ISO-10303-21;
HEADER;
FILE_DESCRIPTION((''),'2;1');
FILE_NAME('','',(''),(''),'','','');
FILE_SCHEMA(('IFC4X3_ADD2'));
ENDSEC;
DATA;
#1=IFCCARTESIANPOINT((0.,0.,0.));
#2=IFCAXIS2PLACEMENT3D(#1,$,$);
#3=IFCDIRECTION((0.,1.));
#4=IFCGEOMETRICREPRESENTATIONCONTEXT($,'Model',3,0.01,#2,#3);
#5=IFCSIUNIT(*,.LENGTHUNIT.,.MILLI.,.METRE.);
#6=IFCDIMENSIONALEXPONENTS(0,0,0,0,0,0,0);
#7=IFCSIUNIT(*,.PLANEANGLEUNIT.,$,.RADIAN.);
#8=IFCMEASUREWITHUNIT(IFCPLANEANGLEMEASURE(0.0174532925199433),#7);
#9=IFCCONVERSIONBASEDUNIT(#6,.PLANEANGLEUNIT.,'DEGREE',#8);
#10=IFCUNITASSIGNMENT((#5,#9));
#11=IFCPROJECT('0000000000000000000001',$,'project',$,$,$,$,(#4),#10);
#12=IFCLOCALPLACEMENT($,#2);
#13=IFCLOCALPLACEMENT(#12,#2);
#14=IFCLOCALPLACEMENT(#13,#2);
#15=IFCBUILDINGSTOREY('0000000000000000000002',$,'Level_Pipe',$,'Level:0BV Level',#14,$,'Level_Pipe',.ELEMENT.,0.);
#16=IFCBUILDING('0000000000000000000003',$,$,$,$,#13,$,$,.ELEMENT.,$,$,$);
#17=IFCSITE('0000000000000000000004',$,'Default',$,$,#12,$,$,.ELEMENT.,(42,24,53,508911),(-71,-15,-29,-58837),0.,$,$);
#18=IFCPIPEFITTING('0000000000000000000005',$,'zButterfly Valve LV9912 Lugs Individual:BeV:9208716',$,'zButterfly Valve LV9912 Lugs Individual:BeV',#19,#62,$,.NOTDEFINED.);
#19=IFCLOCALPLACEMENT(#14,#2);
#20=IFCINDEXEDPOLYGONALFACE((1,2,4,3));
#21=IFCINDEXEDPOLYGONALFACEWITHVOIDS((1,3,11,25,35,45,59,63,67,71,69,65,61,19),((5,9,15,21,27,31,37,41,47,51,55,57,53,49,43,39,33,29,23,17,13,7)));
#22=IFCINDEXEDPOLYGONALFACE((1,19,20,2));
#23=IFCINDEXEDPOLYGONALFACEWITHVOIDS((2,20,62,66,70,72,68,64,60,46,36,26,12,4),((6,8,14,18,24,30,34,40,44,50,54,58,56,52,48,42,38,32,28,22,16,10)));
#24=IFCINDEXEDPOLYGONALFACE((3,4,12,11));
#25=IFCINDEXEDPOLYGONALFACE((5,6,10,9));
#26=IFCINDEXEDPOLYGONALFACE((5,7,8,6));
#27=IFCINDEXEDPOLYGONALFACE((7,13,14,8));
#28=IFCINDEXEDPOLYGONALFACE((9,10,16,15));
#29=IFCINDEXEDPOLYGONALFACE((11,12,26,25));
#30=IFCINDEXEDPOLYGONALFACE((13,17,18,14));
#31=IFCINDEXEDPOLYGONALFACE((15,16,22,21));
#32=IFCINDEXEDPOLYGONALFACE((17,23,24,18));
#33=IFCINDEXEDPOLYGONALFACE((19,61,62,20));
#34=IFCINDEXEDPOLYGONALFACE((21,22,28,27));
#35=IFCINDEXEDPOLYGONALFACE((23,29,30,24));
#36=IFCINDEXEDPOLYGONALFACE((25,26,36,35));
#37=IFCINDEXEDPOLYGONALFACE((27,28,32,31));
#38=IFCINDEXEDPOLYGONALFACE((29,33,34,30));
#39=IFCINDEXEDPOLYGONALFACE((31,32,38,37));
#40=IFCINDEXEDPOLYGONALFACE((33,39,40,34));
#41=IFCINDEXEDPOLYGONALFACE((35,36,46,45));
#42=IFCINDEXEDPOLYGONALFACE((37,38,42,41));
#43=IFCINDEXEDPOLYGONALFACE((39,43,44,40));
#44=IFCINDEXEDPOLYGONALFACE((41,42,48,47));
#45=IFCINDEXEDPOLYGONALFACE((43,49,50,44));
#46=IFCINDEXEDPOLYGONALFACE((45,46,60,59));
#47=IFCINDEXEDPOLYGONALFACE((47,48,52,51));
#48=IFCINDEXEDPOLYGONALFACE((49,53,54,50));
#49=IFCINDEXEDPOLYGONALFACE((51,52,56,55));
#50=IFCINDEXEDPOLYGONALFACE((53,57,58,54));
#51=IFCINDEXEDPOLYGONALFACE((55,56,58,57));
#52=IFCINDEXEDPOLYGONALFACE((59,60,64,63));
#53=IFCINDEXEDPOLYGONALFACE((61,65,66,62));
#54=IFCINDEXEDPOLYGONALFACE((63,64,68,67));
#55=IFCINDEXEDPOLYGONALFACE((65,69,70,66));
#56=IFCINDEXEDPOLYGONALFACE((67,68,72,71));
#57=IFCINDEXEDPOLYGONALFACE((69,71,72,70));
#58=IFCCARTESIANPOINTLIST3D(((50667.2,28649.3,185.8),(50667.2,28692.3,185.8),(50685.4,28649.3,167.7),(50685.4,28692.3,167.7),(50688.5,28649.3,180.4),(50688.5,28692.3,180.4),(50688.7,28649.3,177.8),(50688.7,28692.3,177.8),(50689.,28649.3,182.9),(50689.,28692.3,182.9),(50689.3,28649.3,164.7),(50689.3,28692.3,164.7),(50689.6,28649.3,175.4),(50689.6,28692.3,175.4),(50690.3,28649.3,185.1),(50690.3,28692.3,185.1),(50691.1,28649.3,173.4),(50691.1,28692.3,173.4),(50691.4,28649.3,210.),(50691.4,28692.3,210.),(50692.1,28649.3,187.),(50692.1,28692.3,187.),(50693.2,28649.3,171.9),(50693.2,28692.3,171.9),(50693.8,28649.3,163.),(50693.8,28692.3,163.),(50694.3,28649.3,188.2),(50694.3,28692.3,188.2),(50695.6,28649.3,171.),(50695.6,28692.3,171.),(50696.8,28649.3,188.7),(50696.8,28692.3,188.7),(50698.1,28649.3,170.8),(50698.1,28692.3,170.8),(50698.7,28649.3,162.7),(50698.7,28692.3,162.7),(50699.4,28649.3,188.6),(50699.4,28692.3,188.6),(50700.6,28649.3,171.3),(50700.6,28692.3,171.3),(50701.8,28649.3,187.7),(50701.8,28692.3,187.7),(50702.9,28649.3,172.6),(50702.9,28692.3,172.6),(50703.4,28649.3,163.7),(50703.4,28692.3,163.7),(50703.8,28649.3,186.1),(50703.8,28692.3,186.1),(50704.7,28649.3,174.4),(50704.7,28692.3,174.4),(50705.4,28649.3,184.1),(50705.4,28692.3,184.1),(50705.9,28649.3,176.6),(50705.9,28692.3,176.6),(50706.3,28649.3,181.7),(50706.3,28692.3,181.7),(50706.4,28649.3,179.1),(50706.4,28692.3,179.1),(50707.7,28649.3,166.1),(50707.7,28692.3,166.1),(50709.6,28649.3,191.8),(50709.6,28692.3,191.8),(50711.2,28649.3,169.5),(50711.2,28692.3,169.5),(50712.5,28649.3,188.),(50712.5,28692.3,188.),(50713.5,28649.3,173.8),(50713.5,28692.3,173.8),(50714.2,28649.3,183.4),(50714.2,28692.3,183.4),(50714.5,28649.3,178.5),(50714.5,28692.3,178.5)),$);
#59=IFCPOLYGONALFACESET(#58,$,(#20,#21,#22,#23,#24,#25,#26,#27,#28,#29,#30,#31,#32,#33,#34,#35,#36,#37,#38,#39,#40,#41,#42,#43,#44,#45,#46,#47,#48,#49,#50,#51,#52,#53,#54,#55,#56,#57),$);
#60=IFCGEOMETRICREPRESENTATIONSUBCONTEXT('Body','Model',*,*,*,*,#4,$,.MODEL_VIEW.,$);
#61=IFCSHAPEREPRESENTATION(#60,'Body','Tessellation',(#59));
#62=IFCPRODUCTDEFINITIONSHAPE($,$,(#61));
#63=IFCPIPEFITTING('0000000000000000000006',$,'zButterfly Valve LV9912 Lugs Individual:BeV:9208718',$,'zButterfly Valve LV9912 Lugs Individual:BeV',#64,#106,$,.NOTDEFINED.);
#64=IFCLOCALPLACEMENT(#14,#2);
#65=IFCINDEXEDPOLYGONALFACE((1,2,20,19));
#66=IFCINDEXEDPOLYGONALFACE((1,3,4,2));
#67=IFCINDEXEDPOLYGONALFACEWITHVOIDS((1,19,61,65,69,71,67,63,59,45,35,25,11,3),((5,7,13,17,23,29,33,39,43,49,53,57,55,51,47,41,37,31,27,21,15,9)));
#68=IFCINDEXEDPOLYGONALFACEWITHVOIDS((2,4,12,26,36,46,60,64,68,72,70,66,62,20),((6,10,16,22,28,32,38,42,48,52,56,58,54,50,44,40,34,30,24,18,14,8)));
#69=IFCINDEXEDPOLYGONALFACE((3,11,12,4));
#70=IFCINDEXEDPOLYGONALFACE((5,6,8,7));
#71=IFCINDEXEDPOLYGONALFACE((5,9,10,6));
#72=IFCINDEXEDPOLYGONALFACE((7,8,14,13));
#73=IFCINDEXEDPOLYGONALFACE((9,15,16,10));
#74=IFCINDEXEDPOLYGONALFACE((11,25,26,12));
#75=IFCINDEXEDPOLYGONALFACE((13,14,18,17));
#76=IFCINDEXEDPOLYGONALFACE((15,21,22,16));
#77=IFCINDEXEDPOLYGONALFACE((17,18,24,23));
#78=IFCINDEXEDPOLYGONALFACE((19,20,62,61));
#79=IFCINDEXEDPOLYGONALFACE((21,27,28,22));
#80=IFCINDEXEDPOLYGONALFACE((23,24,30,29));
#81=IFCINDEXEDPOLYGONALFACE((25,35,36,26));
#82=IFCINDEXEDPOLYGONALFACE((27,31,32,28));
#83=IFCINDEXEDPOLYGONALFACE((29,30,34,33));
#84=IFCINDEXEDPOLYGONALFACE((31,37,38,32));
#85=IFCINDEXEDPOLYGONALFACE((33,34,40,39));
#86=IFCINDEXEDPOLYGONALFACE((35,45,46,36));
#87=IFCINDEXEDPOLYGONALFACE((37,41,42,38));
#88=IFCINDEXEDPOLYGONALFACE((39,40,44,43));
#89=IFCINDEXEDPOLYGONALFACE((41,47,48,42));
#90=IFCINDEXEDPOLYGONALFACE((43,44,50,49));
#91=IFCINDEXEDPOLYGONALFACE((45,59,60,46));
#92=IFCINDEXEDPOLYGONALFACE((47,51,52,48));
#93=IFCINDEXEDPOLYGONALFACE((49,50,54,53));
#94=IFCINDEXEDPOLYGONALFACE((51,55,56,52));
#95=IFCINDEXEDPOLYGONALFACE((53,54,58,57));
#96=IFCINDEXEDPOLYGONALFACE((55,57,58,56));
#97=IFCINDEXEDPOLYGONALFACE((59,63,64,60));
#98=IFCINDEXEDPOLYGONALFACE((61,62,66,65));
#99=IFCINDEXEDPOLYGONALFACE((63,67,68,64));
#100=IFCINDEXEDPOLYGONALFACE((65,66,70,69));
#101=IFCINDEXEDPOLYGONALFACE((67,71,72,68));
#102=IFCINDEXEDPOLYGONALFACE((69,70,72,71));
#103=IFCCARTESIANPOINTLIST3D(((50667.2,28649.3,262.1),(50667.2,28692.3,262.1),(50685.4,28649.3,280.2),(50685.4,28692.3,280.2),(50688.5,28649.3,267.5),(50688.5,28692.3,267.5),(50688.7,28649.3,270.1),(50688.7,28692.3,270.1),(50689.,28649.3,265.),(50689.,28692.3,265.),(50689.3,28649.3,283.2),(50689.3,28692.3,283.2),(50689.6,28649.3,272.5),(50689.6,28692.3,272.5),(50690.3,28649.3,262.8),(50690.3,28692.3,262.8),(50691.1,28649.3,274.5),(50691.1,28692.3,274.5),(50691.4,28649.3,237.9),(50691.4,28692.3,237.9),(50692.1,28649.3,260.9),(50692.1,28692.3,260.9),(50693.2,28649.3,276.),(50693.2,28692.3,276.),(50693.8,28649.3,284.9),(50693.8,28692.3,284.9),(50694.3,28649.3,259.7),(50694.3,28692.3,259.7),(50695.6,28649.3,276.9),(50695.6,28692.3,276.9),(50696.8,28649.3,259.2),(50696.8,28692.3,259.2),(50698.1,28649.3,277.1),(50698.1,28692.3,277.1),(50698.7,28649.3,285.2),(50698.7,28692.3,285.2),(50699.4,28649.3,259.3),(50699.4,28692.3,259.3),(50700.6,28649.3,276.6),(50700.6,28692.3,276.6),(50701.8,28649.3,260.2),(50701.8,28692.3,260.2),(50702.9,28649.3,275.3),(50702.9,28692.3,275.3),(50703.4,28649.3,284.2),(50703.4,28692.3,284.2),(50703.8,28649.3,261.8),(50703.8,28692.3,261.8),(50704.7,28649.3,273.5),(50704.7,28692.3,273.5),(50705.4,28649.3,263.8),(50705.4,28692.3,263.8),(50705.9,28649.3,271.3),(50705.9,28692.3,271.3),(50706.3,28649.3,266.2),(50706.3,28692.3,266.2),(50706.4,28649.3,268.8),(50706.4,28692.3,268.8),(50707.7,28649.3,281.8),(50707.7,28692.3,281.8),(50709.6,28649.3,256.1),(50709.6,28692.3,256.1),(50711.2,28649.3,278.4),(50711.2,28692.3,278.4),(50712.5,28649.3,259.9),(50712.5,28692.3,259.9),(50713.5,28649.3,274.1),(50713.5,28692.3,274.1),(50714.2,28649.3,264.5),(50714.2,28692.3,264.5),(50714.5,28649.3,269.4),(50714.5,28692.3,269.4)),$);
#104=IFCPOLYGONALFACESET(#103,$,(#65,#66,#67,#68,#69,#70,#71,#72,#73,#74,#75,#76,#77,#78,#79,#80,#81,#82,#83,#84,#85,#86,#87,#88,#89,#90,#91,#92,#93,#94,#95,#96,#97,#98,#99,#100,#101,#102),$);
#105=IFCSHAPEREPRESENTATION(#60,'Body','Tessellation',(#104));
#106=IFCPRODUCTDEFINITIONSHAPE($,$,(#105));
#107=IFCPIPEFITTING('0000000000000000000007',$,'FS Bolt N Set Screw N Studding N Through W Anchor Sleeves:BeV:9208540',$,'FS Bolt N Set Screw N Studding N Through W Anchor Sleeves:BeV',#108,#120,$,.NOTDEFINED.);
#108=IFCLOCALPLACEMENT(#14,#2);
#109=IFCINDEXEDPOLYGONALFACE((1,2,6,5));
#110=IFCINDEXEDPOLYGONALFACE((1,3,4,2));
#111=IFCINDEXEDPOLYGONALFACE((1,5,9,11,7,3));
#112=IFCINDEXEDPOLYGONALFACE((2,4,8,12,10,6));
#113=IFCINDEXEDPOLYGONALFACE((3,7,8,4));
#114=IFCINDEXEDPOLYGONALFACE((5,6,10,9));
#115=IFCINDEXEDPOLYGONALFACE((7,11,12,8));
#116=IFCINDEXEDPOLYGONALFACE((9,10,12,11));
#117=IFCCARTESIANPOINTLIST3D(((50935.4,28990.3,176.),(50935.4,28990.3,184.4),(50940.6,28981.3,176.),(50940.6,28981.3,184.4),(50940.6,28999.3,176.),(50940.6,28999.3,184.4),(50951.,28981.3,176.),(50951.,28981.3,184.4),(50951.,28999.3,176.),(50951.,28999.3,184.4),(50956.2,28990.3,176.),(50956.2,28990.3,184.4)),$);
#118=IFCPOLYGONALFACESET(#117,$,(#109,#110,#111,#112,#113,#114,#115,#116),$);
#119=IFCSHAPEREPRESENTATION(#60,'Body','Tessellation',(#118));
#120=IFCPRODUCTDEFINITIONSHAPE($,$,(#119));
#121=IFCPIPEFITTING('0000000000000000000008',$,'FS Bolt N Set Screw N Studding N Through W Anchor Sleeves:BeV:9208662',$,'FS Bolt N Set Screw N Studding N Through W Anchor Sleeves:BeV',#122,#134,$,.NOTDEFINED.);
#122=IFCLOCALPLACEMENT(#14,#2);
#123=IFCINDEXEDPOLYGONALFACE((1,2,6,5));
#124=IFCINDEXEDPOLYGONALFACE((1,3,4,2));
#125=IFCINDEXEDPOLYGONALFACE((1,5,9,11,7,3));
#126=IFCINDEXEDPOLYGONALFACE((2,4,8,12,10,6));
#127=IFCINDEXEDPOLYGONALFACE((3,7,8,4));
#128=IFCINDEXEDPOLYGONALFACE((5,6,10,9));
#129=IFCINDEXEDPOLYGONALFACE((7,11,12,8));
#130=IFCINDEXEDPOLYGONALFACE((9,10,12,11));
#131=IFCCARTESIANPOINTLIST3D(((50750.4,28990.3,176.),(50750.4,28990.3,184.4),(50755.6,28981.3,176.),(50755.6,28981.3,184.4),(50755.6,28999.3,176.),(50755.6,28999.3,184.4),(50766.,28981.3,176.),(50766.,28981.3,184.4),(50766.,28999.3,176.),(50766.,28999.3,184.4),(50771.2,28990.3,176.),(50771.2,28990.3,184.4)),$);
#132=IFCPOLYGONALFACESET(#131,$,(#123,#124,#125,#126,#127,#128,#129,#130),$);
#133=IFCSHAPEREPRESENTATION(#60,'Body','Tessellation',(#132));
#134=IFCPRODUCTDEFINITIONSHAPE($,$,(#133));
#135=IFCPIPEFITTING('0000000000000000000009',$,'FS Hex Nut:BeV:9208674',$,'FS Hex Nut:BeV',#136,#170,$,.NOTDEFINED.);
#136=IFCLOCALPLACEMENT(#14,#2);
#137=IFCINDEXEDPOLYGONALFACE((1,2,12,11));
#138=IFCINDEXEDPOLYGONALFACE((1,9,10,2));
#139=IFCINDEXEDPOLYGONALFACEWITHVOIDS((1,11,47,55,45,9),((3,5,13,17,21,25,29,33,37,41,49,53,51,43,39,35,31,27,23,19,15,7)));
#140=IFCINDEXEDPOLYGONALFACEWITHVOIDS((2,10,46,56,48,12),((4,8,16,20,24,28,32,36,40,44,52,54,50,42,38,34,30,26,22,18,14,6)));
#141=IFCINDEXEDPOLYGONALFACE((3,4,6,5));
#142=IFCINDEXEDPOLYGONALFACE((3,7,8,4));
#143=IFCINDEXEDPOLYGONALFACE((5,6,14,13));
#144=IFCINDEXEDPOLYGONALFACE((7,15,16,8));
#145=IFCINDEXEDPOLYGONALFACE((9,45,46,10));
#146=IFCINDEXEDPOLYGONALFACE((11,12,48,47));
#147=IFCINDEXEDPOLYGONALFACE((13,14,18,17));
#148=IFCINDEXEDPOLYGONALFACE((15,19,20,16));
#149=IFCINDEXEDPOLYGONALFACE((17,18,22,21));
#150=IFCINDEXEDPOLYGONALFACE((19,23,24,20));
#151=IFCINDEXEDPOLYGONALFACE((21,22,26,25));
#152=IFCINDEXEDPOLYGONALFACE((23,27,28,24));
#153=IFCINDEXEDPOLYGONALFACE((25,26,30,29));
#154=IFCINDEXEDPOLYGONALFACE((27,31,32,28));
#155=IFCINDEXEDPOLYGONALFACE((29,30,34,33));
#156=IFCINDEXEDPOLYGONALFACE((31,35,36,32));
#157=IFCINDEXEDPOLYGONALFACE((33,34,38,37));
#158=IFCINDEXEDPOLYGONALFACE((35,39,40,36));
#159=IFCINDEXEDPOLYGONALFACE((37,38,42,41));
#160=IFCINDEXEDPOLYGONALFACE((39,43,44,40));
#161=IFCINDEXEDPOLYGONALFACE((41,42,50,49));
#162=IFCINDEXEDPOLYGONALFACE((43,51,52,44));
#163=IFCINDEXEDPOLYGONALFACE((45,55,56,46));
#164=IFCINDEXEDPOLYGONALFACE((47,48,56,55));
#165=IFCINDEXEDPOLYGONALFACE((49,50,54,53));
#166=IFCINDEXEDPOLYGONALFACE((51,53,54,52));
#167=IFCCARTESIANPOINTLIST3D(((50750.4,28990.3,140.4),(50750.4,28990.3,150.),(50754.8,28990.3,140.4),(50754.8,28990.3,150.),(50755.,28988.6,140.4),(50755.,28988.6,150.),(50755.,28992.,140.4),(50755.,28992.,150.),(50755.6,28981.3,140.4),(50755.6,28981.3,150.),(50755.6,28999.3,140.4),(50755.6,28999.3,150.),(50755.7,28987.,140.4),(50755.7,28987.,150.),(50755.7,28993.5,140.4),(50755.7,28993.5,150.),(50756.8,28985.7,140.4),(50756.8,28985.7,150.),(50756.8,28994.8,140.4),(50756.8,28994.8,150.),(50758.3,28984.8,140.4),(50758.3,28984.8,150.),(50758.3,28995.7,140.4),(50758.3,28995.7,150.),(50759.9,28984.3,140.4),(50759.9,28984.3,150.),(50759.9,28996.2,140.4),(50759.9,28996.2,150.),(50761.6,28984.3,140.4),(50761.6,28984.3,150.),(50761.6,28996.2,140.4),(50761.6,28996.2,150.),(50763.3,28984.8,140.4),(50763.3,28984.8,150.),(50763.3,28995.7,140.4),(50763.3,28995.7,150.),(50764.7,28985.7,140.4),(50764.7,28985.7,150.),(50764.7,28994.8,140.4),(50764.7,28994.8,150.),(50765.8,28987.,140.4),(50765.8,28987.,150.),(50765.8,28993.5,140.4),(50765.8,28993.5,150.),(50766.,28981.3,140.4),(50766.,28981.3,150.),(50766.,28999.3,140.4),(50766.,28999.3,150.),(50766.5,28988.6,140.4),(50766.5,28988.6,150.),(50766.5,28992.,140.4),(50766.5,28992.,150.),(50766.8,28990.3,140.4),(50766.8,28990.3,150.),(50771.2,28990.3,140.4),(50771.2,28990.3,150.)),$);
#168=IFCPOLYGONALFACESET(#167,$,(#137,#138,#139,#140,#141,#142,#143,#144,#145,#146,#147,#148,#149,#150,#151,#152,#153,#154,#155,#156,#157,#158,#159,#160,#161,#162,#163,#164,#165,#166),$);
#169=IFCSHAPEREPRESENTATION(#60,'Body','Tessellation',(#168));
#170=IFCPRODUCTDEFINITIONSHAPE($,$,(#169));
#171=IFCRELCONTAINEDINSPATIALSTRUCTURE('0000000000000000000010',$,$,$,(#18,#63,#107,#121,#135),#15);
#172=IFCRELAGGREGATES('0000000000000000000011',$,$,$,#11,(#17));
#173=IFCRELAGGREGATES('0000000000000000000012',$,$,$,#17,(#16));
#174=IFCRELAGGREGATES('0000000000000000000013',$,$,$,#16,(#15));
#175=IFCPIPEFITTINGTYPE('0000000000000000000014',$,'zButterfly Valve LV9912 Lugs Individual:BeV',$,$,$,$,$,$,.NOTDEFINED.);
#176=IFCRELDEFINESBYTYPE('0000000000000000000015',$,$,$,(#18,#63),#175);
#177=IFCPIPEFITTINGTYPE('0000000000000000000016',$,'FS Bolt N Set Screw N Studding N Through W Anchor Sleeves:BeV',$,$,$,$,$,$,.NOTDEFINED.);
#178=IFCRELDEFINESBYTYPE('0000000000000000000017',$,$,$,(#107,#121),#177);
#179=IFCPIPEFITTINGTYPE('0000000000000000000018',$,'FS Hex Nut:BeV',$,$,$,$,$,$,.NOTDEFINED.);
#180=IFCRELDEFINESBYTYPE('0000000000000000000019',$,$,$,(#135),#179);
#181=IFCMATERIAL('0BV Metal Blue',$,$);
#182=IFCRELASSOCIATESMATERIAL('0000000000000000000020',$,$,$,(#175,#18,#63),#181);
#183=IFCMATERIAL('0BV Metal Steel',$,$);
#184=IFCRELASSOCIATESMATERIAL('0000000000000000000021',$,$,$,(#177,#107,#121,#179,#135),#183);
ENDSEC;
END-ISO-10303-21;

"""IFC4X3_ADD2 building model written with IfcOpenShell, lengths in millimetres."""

from ifc_helpers import new_model, entity, si_unit, converted_unit, direction, frame, frame_2d, origin, place, context, subcontext, project, spatial, polyline, circle_curve, parameter, trimmed, segment, composite_curve, outline, extrude, source, transform, mapped, material, type_object, type_shapes, element, save


model = new_model("IFC4X3_ADD2")

# Units and contexts
model_context = context("Model", 3, precision=0.01, world=origin(), true_north=direction((0.0, 1.0)))
body_context = subcontext(model_context, "Body", "Model", "MODEL_VIEW")
ifc_project = project(units=[si_unit("LENGTHUNIT", "METRE", prefix="MILLI"), converted_unit("PLANEANGLEUNIT", "DEGREE", entity("IfcPlaneAngleMeasure", 0.0174532925199433), si_unit("PLANEANGLEUNIT", "RADIAN"), dimensions=[0, 0, 0, 0, 0, 0, 0])], contexts=[model_context])

# Site, building, storey
site_placement = place(None, origin())
site = spatial("IfcSite", under=ifc_project, at=site_placement, Name="Default", CompositionType="ELEMENT", RefLatitude=(42, 24, 53, 508911), RefLongitude=(-71, -15, -29, -58837), RefElevation=0.0)
building_placement = place(site_placement, origin())
building = spatial("IfcBuilding", under=site, at=building_placement, CompositionType="ELEMENT")
storey_placement = place(building_placement, origin())
storey = spatial("IfcBuildingStorey", under=building, at=storey_placement, Name="Level_Pipe", ObjectType="Level:0BV Level", LongName="Level_Pipe", CompositionType="ELEMENT", Elevation=0.0)

# Pipe fittings
ifc_material_1 = material(Name="0BV Metal Blue")
pipe_fitting_type_1 = type_object("IfcPipeFittingType", Name="zButterfly Valve LV9912 Lugs Individual:BeV", PredefinedType="NOTDEFINED", material=ifc_material_1)
shared_shape_1 = source(origin(), body_context, "Body", "SweptSolid", [
    extrude(outline(composite_curve([segment(polyline([(-17.1, -12.8), (17.1, -12.8)]), True, "CONTINUOUS"), segment(polyline([(17.1, -12.8), (17.1, 12.8)]), True, "CONTINUOUS"), segment(trimmed(circle_curve(frame_2d((0.0, 12.8), x_axis=(1.0, 0.0)), 17.1), [parameter(360.0)], [parameter(180.0)], True, "PARAMETER"), True, "CONTINUOUS"), segment(polyline([(-17.1, 12.8), (-17.1, -12.8)]), True, "CONTINUOUS")], self_intersect=False), holes=[composite_curve([segment(trimmed(circle_curve(frame_2d((0.0, 12.8), x_axis=(1.0, 0.0)), 9.0), [parameter(0.0)], [parameter(180.0)], True, "PARAMETER"), False, "CONTINUOUS"), segment(trimmed(circle_curve(frame_2d((0.0, 12.8), x_axis=(1.0, 0.0)), 9.0), [parameter(180.0)], [parameter(0.0)], True, "PARAMETER"), False, "CONTINUOUS")], self_intersect=False)]), frame((0.0, -12.8, -21.5)), (0.0, 0.0, 1.0), 43.0),
])
type_shapes(pipe_fitting_type_1, [shared_shape_1])
for number, where, z_axis, x_axis, name in (
    (1, (50697.5, 28670.8, 179.8), (0.0, -1.0, 0.0), (-0.707107, 0.0, -0.707107), "zButterfly Valve LV9912 Lugs Individual:BeV:9208716"),
    (2, (50697.5, 28670.8, 268.1), (0.0, -1.0, 0.0), (0.707107, 0.0, -0.707107), "zButterfly Valve LV9912 Lugs Individual:BeV:9208718"),
):
    element("IfcPipeFitting", number, at=place(storey_placement, frame(where, z_axis=z_axis, x_axis=x_axis)), inside=storey, type_object=pipe_fitting_type_1, material=ifc_material_1, Name=name, ObjectType="zButterfly Valve LV9912 Lugs Individual:BeV", PredefinedType="NOTDEFINED", context=body_context, shape_type="MappedRepresentation", body=[
        mapped(shared_shape_1, transform((0.0, 0.0, 0.0), scale=1.0)),
    ])
ifc_material_2 = material(Name="0BV Metal Steel")
pipe_fitting_type_2 = type_object("IfcPipeFittingType", Name="FS Bolt N Set Screw N Studding N Through W Anchor Sleeves:BeV", PredefinedType="NOTDEFINED", material=ifc_material_2)
shared_shape_2 = source(origin(), body_context, "Body", "SweptSolid", [
    extrude(outline(polyline([(-5.2, -9.0), (5.2, -9.0), (10.4, 0.0), (5.2, 9.0), (-5.2, 9.0), (-10.4, 0.0), (-5.2, -9.0)])), frame((-8.4, 0.0, 0.0), z_axis=(1.0, 0.0, 0.0), x_axis=(0.0, -0.5, -0.866025)), (0.0, 0.0, 1.0), 8.4),
])
type_shapes(pipe_fitting_type_2, [shared_shape_2])
for number, where, z_axis, x_axis, name in (
    (3, (50945.8, 28990.3, 176.0), (0.0, 1.0, 0.0), (0.0, 0.0, -1.0), "FS Bolt N Set Screw N Studding N Through W Anchor Sleeves:BeV:9208540"),
    (4, (50760.8, 28990.3, 176.0), (0.0, 1.0, 0.0), (0.0, 0.0, -1.0), "FS Bolt N Set Screw N Studding N Through W Anchor Sleeves:BeV:9208662"),
):
    element("IfcPipeFitting", number, at=place(storey_placement, frame(where, z_axis=z_axis, x_axis=x_axis)), inside=storey, type_object=pipe_fitting_type_2, material=ifc_material_2, Name=name, ObjectType="FS Bolt N Set Screw N Studding N Through W Anchor Sleeves:BeV", PredefinedType="NOTDEFINED", context=body_context, shape_type="MappedRepresentation", body=[
        mapped(shared_shape_2, transform((0.0, 0.0, 0.0), scale=1.0)),
    ])
pipe_fitting_type_3 = type_object("IfcPipeFittingType", Name="FS Hex Nut:BeV", PredefinedType="NOTDEFINED", material=ifc_material_2)
shared_shape_3 = source(origin(), body_context, "Body", "SweptSolid", [
    extrude(outline(polyline([(-5.2, -9.0), (5.2, -9.0), (10.4, 0.0), (5.2, 9.0), (-5.2, 9.0), (-10.4, 0.0), (-5.2, -9.0)]), holes=[composite_curve([segment(trimmed(circle_curve(frame_2d((0.0, 0.0), x_axis=(-0.5, 0.866025)), 6.0), [parameter(0.0)], [parameter(180.0)], True, "PARAMETER"), False, "CONTINUOUS"), segment(trimmed(circle_curve(frame_2d((0.0, 0.0), x_axis=(-0.5, 0.866025)), 6.0), [parameter(180.0)], [parameter(360.0)], True, "PARAMETER"), False, "CONTINUOUS")], self_intersect=False)]), frame((0.0, 10.4, 9.0), z_axis=(1.0, 0.0, 0.0), x_axis=(0.0, -0.5, -0.866025)), (0.0, 0.0, 1.0), 9.6),
])
type_shapes(pipe_fitting_type_3, [shared_shape_3])
for number, where, z_axis, x_axis, name in (
    (5, (50771.2, 28981.3, 150.0), (0.0, 1.0, 0.0), (0.0, 0.0, -1.0), "FS Hex Nut:BeV:9208674"),
):
    element("IfcPipeFitting", number, at=place(storey_placement, frame(where, z_axis=z_axis, x_axis=x_axis)), inside=storey, type_object=pipe_fitting_type_3, material=ifc_material_2, Name=name, ObjectType="FS Hex Nut:BeV", PredefinedType="NOTDEFINED", context=body_context, shape_type="MappedRepresentation", body=[
        mapped(shared_shape_3, transform((0.0, 0.0, 0.0), scale=1.0)),
    ])

save(model, "model.ifc")
